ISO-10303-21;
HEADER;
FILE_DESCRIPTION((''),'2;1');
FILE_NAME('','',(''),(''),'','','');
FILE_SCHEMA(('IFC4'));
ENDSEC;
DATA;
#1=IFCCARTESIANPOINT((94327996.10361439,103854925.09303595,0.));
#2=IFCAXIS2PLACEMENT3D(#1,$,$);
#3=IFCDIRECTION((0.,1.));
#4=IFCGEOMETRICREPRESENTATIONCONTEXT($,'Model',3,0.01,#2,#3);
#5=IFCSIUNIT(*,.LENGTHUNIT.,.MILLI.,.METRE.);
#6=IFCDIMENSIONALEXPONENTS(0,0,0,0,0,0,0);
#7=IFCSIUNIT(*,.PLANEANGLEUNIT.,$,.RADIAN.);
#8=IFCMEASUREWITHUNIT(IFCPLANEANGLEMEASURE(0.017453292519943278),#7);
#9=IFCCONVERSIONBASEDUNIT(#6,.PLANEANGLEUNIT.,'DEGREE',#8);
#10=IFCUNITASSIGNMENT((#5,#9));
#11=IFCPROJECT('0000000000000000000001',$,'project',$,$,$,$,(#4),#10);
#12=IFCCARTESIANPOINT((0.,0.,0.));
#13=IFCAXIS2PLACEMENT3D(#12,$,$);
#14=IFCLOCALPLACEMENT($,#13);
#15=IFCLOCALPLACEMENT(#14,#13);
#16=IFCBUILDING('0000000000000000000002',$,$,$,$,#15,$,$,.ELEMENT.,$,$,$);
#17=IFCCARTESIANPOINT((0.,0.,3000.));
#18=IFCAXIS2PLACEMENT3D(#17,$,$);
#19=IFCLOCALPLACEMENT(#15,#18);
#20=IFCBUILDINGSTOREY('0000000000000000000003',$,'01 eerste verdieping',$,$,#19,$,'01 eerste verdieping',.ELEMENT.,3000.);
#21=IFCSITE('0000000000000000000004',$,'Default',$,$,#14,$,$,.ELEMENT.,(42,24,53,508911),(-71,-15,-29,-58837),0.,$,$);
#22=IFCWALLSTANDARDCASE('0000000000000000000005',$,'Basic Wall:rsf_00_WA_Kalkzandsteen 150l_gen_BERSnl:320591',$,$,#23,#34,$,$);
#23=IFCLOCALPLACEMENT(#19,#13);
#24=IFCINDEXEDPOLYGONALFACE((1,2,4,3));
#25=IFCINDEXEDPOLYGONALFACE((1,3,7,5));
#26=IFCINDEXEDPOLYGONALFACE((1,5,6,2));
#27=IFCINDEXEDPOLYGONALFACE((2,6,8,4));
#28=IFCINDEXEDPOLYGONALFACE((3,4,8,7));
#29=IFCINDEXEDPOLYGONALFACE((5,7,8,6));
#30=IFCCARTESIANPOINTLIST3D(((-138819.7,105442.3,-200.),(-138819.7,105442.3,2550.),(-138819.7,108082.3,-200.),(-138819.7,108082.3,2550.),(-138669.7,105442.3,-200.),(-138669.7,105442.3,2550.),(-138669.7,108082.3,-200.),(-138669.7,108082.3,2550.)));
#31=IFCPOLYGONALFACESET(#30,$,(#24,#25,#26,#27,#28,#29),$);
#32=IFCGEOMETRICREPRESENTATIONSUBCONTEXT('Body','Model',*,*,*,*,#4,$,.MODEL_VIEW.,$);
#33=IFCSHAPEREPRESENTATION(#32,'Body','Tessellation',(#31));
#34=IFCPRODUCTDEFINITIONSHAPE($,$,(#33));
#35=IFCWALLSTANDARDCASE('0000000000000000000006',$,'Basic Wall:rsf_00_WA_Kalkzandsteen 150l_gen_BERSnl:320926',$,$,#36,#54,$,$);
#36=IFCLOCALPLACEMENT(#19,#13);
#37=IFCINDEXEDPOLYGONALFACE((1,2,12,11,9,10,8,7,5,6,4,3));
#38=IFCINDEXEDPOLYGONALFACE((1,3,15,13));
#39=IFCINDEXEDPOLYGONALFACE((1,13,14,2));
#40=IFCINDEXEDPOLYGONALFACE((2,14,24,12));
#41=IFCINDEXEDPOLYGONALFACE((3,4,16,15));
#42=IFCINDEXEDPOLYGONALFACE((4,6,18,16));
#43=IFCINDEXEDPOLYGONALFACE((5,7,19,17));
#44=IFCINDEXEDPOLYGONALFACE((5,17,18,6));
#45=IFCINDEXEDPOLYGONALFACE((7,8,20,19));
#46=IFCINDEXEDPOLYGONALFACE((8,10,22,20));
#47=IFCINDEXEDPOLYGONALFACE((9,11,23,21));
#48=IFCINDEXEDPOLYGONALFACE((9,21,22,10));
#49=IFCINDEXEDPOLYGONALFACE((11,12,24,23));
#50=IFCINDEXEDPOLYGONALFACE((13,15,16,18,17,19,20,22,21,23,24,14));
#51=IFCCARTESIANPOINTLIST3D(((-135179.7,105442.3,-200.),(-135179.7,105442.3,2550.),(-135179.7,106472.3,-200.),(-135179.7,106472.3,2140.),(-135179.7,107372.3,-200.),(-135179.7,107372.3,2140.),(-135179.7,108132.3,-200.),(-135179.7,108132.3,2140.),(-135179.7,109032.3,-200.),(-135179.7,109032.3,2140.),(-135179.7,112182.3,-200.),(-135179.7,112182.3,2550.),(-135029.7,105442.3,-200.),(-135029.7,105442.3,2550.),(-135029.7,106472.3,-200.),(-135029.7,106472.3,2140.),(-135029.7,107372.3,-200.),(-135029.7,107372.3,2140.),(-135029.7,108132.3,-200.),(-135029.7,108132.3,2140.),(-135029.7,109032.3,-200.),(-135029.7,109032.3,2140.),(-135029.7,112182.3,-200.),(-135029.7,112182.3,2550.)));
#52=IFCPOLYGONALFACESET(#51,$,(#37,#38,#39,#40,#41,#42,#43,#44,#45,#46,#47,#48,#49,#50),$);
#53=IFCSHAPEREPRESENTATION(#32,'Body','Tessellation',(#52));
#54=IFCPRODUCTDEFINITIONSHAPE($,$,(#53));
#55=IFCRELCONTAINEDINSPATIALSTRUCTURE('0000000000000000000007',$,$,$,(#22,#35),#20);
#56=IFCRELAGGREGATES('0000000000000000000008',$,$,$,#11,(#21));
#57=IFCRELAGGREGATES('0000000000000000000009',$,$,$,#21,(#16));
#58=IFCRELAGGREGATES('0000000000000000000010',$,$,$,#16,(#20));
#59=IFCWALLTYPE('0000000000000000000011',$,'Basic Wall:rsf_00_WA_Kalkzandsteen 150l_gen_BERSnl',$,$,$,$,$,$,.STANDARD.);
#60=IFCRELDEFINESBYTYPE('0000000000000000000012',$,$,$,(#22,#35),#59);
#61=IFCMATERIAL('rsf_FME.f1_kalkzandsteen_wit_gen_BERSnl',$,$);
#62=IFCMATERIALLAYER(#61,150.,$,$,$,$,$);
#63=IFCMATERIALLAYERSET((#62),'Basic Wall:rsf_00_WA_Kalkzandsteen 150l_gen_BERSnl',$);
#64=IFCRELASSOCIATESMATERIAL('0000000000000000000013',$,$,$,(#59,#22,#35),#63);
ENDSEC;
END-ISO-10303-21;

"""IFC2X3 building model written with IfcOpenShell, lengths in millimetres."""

from ifc_helpers import new_model, entity, si_unit, converted_unit, direction, frame, frame_2d, origin, place, context, subcontext, project, spatial, polyline, rectangle, extrude, clip, bounded_halfspace, material, layer, layer_set, layer_usage, type_object, element, save


model = new_model("IFC2X3")

# Units and contexts
model_context = context("Model", 3, precision=0.01, world=frame((94327996.10361439, 103854925.09303595, 0.0)), true_north=direction((0.0, 1.0)))
body_context = subcontext(model_context, "Body", "Model", "MODEL_VIEW")
ifc_project = project(units=[si_unit("LENGTHUNIT", "METRE", prefix="MILLI"), converted_unit("PLANEANGLEUNIT", "DEGREE", entity("IfcPlaneAngleMeasure", 0.017453292519943278), si_unit("PLANEANGLEUNIT", "RADIAN"), dimensions=[0, 0, 0, 0, 0, 0, 0])], contexts=[model_context])

# Site, building, storey
site_placement = place(None, origin())
site = spatial("IfcSite", under=ifc_project, at=site_placement, Name="Default", CompositionType="ELEMENT", RefLatitude=(42, 24, 53, 508911), RefLongitude=(-71, -15, -29, -58837), RefElevation=0.0)
building_placement = place(site_placement, origin())
building = spatial("IfcBuilding", under=site, at=building_placement, CompositionType="ELEMENT")
storey_placement = place(building_placement, frame((0.0, 0.0, 3000.0)))
storey = spatial("IfcBuildingStorey", under=building, at=storey_placement, Name="01 eerste verdieping", LongName="01 eerste verdieping", CompositionType="ELEMENT", Elevation=3000.0)

# Shared definitions
ifc_material_1 = material(Name="rsf_FME.f1_kalkzandsteen_wit_gen_BERSnl")
ifc_layer_1 = layer(ifc_material_1, 150.0)
ifc_layer_set_1 = layer_set([ifc_layer_1], Name="Basic Wall:rsf_00_WA_Kalkzandsteen 150l_gen_BERSnl")
wall_type = type_object("IfcWallType", Name="Basic Wall:rsf_00_WA_Kalkzandsteen 150l_gen_BERSnl", PredefinedType="STANDARD", material=ifc_layer_set_1)

# Wall
ifc_layer_usage_1 = layer_usage(ifc_layer_set_1, "AXIS2", "POSITIVE", -75.0)
wall_1_placement = place(storey_placement, frame((-138744.7, 105442.3, -200.0), z_axis=(0.0, 0.0, 1.0), x_axis=(0.0, 1.0, 0.0)))
element("IfcWallStandardCase", 1, at=wall_1_placement, inside=storey, type_object=wall_type, material=ifc_layer_usage_1, Name="Basic Wall:rsf_00_WA_Kalkzandsteen 150l_gen_BERSnl:320591", context=body_context, shape_type="Clipping", body=[
    clip(extrude(rectangle(XDim=2640.0, YDim=150.0, at=frame_2d((1320.0, 0.0), x_axis=(-1.0, 0.0))), origin(), (0.0, 0.0, 1.0), 2750.0), bounded_halfspace(frame((0.0, -75.0, 2750.0), z_axis=(0.0, 0.0, -1.0), x_axis=(0.0, -1.0, 0.0)), True, frame((0.0, -75.0, 2750.0)), polyline([(0.0, 0.0), (2640.0, 0.0), (2640.0, 150.0), (0.0, 150.0), (0.0, 0.0)]))),
])

# Wall, openings
ifc_layer_usage_2 = layer_usage(ifc_layer_set_1, "AXIS2", "NEGATIVE", 75.0)
wall_2_placement = place(storey_placement, frame((-135104.7, 105442.3, -200.0), z_axis=(0.0, 0.0, 1.0), x_axis=(0.0, 1.0, 0.0)))
wall_2 = element("IfcWallStandardCase", 2, at=wall_2_placement, inside=storey, type_object=wall_type, material=ifc_layer_usage_2, Name="Basic Wall:rsf_00_WA_Kalkzandsteen 150l_gen_BERSnl:320926", context=body_context, shape_type="Clipping", body=[
    clip(extrude(rectangle(XDim=6740.0, YDim=150.0, at=frame_2d((3370.0, 0.0), x_axis=(1.0, 0.0))), origin(), (0.0, 0.0, 1.0), 2750.0), bounded_halfspace(frame((0.0, -75.0, 2750.0), z_axis=(0.0, 0.0, -1.0), x_axis=(0.0, -1.0, 0.0)), True, frame((0.0, -75.0, 2750.0)), polyline([(0.0, 0.0), (6740.0, 0.0), (6740.0, 150.0), (0.0, 150.0), (0.0, 0.0)]))),
])
opening_1_placement = place(wall_2_placement, frame((-105442.3, -135104.7, 200.0), z_axis=(0.0, 0.0, 1.0), x_axis=(0.0, -1.0, 0.0)))
element("IfcOpeningElement", 3, at=opening_1_placement, cuts=wall_2, ObjectType="Opening", context=body_context, shape_type="SweptSolid", body=[
    extrude(rectangle(XDim=2340.0, YDim=900.0, at=frame_2d((0.0, 0.0), x_axis=(0.0, 1.0))), frame((-133505.7, 108582.3, 970.0), z_axis=(-1.0, 0.0, 0.0), x_axis=(0.0, -1.0, 0.0)), (0.0, 0.0, 1.0), 3048.0),
])
opening_2_placement = place(wall_2_placement, frame((-105442.3, -135104.7, 200.0), z_axis=(0.0, 0.0, 1.0), x_axis=(0.0, -1.0, 0.0)))
element("IfcOpeningElement", 4, at=opening_2_placement, cuts=wall_2, ObjectType="Opening", context=body_context, shape_type="SweptSolid", body=[
    extrude(rectangle(XDim=2340.0, YDim=900.0, at=frame_2d((0.0, 0.0), x_axis=(1.0, 0.0))), frame((-133655.7, 106922.3, 970.0), z_axis=(-1.0, 0.0, 0.0), x_axis=(0.0, 0.0, 1.0)), (0.0, 0.0, 1.0), 3048.0),
])

save(model, "model.ifc")
